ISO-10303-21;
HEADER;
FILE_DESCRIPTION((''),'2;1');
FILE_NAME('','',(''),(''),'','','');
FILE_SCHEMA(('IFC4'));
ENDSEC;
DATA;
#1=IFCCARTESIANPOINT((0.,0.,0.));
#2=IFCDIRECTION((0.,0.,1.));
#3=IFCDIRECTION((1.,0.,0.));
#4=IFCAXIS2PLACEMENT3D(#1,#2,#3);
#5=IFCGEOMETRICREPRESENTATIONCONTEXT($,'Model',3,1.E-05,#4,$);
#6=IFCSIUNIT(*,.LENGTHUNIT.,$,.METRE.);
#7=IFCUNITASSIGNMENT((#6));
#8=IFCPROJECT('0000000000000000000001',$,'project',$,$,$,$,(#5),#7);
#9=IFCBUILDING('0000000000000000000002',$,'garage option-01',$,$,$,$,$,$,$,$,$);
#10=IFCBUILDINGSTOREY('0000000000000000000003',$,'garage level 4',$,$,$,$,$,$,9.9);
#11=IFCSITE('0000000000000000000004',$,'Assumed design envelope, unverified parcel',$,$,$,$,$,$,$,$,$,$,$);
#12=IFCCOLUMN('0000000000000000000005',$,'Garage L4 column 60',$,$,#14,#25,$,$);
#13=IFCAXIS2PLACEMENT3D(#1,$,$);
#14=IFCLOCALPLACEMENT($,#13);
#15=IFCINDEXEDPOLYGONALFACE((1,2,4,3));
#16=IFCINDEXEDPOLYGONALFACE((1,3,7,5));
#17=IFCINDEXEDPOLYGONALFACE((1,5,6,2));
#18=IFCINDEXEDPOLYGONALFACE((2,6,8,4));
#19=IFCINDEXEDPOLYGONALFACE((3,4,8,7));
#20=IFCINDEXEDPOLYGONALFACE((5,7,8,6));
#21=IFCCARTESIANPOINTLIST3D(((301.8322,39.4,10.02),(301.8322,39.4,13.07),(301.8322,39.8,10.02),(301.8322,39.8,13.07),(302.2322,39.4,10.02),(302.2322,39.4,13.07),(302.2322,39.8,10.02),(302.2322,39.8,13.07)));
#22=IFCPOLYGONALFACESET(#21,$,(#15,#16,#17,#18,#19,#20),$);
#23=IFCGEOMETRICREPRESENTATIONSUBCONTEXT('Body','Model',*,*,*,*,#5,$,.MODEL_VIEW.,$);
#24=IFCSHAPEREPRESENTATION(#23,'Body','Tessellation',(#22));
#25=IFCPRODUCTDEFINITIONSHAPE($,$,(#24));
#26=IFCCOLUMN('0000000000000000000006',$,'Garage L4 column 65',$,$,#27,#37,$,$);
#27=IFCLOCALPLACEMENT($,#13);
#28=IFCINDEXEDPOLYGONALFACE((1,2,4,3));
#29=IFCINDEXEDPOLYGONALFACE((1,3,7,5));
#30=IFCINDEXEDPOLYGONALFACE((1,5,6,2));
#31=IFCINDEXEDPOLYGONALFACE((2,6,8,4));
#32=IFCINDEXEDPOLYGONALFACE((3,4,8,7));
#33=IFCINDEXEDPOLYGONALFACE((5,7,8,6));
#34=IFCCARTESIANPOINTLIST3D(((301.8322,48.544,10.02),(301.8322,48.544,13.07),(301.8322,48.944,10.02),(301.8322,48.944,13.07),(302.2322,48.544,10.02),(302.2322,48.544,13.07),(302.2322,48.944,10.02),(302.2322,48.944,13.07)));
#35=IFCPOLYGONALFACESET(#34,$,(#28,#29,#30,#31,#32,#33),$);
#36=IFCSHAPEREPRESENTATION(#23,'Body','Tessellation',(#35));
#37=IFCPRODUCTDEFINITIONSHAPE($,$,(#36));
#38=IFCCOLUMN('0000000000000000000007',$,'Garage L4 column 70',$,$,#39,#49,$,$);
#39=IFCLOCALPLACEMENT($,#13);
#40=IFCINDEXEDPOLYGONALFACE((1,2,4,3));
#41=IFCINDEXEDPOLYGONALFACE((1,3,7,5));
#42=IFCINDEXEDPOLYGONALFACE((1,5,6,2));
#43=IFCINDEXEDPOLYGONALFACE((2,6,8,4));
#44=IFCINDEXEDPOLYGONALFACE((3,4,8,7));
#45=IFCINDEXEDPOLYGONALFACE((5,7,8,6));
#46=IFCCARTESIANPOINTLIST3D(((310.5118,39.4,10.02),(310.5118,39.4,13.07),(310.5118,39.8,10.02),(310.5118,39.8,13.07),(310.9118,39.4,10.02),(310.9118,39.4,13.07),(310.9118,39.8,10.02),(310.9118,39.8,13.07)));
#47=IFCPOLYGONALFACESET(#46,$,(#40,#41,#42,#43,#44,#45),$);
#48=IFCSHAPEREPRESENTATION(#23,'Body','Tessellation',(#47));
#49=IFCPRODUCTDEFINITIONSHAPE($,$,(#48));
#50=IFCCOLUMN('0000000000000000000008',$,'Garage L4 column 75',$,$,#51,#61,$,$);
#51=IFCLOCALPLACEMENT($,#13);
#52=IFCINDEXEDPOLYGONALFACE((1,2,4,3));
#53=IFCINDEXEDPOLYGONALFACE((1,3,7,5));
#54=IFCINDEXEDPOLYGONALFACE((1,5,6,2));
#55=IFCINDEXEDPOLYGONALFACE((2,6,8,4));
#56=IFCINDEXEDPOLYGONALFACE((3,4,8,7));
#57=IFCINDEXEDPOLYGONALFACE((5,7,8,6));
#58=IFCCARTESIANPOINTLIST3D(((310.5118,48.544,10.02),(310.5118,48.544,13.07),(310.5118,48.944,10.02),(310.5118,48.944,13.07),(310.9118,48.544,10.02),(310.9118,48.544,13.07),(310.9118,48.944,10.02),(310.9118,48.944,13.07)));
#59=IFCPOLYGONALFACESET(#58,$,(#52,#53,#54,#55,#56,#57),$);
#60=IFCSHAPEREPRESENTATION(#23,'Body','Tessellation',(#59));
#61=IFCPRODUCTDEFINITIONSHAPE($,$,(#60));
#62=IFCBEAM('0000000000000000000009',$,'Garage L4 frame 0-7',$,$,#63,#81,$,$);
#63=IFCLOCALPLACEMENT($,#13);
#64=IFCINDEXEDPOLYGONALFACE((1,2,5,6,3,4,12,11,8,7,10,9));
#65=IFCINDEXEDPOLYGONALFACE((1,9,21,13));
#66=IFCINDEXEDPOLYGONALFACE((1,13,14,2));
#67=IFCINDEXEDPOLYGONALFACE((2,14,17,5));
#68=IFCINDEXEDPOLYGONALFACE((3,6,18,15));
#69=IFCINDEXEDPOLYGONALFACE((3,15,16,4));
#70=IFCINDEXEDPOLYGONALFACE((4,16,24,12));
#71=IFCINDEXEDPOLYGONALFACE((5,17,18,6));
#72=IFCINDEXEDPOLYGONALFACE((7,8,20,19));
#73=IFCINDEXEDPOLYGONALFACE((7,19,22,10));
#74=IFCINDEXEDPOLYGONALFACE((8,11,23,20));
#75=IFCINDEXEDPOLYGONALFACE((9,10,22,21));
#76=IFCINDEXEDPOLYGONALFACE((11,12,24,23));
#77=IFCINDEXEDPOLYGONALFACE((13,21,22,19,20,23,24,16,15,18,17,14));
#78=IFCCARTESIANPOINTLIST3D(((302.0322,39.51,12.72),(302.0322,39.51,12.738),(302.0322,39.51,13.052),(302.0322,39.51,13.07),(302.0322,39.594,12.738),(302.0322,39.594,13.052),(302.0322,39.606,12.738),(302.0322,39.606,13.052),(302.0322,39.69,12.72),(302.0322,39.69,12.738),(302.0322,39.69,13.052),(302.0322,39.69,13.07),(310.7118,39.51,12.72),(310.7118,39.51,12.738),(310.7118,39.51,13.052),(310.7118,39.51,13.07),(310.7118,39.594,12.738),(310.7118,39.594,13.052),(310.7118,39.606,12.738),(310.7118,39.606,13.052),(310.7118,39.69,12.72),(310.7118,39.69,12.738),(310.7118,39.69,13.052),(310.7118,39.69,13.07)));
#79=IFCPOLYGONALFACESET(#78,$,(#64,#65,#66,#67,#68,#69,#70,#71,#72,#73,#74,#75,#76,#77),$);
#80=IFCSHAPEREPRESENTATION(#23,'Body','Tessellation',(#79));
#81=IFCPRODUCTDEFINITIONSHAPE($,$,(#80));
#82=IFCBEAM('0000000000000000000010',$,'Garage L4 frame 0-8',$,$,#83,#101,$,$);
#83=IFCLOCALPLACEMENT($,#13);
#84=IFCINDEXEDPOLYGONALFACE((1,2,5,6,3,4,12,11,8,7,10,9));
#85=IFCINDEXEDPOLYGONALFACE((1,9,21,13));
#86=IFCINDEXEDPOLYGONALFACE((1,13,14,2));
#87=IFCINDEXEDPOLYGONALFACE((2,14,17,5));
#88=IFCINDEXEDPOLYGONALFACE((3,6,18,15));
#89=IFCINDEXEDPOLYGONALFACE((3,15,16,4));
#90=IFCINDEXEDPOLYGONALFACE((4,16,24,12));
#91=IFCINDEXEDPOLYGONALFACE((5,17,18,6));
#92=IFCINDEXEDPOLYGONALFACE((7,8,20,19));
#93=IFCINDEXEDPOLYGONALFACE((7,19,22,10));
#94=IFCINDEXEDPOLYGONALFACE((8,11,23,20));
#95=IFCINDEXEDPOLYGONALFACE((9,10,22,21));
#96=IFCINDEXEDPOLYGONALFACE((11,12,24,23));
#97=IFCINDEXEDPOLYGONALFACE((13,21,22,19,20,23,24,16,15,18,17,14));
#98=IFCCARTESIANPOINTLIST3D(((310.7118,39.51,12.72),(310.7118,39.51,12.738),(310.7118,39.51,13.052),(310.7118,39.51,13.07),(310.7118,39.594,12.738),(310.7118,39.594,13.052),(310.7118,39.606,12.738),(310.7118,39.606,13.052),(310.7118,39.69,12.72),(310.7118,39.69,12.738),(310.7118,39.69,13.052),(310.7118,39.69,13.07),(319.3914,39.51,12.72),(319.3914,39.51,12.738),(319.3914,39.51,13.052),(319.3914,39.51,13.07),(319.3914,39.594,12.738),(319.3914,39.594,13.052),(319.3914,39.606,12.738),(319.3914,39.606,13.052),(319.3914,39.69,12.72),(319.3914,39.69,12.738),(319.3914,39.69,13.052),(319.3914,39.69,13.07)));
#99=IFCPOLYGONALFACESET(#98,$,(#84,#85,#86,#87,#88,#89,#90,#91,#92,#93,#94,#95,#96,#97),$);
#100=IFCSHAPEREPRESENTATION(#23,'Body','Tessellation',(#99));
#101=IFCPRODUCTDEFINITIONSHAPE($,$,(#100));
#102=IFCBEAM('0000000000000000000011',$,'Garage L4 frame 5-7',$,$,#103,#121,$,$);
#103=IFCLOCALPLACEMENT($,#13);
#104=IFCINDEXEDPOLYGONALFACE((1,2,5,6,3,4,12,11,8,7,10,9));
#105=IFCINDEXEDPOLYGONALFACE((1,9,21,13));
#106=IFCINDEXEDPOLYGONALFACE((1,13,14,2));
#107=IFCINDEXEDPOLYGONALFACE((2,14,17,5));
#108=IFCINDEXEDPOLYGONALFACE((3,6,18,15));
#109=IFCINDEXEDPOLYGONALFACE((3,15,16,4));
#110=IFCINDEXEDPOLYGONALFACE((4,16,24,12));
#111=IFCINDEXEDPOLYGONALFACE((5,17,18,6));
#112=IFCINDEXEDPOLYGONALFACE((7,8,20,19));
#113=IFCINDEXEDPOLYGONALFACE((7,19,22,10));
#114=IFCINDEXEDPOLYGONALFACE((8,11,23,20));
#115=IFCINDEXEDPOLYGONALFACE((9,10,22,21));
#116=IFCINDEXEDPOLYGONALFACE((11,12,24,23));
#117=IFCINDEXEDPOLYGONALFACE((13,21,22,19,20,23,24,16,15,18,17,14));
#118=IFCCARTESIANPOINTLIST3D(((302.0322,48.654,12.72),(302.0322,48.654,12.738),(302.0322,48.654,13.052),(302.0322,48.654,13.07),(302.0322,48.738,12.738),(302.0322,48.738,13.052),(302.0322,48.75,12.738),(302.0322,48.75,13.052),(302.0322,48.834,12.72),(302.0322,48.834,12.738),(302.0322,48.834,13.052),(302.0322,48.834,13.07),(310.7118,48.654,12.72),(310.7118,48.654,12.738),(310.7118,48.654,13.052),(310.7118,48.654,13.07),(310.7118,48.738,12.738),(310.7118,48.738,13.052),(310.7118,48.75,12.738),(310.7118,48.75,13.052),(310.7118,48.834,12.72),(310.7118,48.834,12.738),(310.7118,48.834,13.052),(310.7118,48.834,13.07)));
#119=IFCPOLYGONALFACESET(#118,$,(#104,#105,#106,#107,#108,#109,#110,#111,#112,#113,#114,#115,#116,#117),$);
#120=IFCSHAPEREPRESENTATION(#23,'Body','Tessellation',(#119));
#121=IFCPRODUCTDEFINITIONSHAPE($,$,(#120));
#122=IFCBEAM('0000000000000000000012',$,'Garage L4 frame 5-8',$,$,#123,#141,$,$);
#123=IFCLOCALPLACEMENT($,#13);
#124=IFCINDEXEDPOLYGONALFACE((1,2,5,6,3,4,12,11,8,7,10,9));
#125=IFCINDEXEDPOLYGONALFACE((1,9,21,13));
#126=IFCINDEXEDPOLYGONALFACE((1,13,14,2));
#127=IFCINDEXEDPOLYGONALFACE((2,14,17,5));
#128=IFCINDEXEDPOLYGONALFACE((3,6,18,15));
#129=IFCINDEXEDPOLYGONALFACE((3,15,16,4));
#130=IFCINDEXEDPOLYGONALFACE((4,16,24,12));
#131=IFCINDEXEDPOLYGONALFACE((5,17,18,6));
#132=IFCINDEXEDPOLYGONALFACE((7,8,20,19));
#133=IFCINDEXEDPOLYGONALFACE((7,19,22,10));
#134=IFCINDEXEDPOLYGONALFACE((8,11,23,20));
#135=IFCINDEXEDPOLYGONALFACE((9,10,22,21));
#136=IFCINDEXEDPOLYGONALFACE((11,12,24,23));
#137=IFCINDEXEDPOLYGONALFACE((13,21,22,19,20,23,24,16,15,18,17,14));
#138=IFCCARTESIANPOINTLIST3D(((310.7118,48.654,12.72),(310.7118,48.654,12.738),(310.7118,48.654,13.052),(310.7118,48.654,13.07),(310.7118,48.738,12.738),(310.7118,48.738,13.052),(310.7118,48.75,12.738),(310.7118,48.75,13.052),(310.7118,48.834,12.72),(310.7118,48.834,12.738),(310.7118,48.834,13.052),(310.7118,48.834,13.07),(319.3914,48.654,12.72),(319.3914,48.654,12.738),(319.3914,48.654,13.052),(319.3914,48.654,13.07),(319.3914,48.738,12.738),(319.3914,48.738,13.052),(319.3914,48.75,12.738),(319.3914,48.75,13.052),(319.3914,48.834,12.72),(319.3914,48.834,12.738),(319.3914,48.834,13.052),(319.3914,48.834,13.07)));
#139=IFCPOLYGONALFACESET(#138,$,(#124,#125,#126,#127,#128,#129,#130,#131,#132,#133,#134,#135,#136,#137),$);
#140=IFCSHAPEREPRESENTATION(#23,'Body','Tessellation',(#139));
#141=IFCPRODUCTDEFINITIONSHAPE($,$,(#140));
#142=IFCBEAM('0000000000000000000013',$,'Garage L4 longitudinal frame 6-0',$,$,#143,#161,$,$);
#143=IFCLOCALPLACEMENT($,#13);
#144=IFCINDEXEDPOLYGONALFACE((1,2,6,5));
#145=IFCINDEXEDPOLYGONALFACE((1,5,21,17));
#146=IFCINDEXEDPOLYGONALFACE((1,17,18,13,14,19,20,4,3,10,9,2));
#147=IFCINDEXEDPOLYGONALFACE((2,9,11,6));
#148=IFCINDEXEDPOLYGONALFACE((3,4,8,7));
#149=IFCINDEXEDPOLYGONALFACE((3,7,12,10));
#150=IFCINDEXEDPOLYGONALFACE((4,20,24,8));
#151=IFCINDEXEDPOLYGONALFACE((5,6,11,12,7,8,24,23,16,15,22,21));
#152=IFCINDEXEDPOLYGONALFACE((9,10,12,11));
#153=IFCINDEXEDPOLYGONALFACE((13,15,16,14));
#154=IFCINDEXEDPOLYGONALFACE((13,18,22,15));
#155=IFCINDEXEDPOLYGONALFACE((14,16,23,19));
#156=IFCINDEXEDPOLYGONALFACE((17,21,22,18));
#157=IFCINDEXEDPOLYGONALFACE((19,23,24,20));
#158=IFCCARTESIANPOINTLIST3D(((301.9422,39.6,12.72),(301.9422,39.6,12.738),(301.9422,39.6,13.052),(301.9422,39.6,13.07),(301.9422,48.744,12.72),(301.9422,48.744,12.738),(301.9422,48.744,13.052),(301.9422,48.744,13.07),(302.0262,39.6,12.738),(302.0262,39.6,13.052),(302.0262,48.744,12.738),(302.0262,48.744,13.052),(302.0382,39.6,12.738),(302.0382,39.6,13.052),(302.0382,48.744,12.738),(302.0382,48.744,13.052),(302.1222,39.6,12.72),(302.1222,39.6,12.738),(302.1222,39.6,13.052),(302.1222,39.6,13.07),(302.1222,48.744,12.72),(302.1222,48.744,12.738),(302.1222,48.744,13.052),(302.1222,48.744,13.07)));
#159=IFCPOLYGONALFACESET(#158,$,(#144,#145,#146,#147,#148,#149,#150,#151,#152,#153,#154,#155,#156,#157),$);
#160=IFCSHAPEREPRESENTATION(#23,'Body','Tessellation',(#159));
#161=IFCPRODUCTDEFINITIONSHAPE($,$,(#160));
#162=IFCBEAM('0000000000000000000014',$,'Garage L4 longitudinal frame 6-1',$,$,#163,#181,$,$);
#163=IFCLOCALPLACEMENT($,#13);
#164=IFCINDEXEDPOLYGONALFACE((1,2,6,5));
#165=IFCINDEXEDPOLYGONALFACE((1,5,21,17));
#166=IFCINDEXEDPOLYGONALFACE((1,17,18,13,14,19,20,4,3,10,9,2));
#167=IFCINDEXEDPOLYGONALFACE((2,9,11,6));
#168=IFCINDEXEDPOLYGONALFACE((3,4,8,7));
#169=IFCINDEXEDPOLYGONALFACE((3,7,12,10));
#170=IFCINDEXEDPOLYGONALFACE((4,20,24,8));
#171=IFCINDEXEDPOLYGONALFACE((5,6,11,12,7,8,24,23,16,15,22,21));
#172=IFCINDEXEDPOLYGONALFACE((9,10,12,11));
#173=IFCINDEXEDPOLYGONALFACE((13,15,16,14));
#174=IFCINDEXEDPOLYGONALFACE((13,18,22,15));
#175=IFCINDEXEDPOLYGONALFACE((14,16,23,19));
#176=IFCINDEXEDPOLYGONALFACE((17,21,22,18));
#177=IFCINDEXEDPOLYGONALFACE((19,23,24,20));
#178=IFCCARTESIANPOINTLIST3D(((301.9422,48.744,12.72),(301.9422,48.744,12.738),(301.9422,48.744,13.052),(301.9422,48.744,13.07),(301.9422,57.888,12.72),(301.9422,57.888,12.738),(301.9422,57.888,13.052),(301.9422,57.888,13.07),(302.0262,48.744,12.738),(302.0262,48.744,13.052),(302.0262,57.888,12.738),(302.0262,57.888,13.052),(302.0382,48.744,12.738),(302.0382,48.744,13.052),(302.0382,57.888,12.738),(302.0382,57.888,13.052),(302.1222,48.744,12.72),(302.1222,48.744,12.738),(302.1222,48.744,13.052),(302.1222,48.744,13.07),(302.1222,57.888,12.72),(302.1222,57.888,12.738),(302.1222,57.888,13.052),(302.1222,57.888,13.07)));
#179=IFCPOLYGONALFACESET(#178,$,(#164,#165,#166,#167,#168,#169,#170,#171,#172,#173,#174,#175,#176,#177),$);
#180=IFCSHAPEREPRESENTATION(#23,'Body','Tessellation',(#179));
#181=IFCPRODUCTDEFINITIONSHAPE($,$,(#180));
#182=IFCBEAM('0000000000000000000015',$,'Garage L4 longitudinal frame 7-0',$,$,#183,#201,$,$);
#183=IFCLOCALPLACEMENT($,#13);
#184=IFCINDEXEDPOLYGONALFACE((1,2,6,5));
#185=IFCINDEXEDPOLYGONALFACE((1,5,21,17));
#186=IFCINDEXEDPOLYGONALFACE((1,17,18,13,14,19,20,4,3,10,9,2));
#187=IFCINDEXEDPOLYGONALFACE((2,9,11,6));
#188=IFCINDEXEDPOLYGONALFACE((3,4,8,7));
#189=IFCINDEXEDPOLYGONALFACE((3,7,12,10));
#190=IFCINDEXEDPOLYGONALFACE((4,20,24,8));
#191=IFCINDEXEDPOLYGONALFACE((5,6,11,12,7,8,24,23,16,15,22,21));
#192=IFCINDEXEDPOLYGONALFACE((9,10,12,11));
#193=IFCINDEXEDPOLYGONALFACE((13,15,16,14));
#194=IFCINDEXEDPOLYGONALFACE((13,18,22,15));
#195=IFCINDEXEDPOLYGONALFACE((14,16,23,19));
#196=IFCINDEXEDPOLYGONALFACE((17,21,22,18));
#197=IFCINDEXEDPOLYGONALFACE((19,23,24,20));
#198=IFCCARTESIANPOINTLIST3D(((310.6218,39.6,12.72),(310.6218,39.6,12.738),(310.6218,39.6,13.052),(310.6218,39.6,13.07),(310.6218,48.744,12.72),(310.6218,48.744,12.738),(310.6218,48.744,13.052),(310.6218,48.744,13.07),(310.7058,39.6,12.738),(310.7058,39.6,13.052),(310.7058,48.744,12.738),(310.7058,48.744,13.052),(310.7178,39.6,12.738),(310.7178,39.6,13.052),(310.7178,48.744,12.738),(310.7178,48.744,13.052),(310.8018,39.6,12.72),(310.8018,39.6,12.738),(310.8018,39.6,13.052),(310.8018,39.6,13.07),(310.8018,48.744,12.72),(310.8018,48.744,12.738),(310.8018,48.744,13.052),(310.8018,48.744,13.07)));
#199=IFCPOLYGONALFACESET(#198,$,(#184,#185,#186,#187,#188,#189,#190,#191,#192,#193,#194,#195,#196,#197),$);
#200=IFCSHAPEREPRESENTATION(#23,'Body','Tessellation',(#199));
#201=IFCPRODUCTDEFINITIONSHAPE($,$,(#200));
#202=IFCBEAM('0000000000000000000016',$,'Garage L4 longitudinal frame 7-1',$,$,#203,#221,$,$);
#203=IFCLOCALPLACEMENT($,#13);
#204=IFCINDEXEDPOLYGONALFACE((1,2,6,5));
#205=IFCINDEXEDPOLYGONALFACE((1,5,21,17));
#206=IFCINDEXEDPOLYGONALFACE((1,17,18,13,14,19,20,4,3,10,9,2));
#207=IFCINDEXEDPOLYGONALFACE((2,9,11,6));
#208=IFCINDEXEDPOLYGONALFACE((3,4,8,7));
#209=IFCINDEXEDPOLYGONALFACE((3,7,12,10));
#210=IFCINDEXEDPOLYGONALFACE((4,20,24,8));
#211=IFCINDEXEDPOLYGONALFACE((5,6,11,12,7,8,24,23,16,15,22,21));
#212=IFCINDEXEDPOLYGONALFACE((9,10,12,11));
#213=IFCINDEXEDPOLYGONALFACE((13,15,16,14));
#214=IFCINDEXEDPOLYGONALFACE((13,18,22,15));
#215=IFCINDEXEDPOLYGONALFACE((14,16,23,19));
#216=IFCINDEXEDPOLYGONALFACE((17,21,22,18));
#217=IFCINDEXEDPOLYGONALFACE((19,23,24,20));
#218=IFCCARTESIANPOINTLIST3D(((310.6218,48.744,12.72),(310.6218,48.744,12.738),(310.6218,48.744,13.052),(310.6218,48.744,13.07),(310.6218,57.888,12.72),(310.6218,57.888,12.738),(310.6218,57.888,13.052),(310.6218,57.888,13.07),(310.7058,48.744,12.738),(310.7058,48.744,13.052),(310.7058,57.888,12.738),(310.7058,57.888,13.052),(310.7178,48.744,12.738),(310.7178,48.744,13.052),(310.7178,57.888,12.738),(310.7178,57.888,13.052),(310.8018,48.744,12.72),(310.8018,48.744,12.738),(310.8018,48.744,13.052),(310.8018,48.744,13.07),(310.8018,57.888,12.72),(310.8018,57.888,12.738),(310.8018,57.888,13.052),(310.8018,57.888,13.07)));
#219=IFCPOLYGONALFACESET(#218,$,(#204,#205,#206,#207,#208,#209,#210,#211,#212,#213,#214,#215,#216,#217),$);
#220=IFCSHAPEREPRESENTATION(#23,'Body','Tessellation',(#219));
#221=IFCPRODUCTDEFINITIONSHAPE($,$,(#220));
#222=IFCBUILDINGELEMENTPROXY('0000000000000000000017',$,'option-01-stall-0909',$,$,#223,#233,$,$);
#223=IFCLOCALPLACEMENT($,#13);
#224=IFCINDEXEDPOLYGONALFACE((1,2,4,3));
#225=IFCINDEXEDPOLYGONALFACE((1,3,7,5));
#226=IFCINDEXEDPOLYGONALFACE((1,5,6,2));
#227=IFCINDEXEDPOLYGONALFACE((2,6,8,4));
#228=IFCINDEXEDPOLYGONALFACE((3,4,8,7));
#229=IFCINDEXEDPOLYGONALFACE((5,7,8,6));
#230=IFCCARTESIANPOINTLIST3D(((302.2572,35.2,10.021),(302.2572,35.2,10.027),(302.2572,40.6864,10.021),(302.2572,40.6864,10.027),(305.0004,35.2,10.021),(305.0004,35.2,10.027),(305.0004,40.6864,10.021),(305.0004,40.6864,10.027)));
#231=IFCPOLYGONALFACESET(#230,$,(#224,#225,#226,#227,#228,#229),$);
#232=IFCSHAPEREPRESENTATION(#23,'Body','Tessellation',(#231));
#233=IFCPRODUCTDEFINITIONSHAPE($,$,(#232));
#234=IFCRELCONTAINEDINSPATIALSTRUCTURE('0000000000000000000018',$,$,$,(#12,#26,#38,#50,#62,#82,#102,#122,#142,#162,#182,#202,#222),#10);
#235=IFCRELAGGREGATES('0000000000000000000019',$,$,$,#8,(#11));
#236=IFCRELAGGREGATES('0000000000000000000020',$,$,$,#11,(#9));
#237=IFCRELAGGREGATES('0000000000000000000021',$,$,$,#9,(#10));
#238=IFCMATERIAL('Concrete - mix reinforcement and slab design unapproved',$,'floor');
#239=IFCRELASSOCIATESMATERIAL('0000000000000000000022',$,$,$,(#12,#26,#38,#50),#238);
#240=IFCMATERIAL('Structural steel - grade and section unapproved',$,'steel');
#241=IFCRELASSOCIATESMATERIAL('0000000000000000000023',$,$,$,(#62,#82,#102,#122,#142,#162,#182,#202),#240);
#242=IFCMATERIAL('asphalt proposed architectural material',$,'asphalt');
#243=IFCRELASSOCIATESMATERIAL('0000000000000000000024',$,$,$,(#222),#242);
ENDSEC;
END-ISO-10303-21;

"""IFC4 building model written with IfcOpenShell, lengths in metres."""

from ifc_helpers import new_model, si_unit, frame, origin_with_axes, place, context, subcontext, project, spatial, rectangle, i_section, extrude, material, element, save


model = new_model("IFC4")

# Units and contexts
model_context = context("Model", 3, precision=1e-05, world=origin_with_axes())
body_context = subcontext(model_context, "Body", "Model", "MODEL_VIEW")
ifc_project = project(units=[si_unit("LENGTHUNIT", "METRE")], contexts=[model_context])

# Site, building, storey
site = spatial("IfcSite", under=ifc_project, Name="Assumed design envelope, unverified parcel")
building = spatial("IfcBuilding", under=site, Name="garage option-01")
storey = spatial("IfcBuildingStorey", under=building, Name="garage level 4", Elevation=9.9)

# Columns
ifc_material_1 = material(Name="Concrete - mix reinforcement and slab design unapproved", Category="floor")
for number, where, z_axis, x_axis, name in (
    (1, (302.0322, 39.6, 10.02), (0.0, 0.0, 1.0), (1.0, 0.0, 0.0), "Garage L4 column 60"),
    (2, (302.0322, 48.744, 10.02), (0.0, 0.0, 1.0), (1.0, 0.0, 0.0), "Garage L4 column 65"),
    (3, (310.7118, 39.6, 10.02), (0.0, 0.0, 1.0), (1.0, 0.0, 0.0), "Garage L4 column 70"),
    (4, (310.7118, 48.744, 10.02), (0.0, 0.0, 1.0), (1.0, 0.0, 0.0), "Garage L4 column 75"),
):
    element("IfcColumn", number, at=place(None, frame(where, z_axis=z_axis, x_axis=x_axis)), inside=storey, material=ifc_material_1, Name=name, context=body_context, shape_type="SweptSolid", body=[
        extrude(rectangle(XDim=0.4, YDim=0.4), origin_with_axes(), (0.0, 0.0, 1.0), 3.05),
    ])

# Beams
ifc_material_2 = material(Name="Structural steel - grade and section unapproved", Category="steel")
for number, where, z_axis, x_axis, name in (
    (5, (302.0322, 39.6, 12.895), (1.0, 0.0, 0.0), (0.0, 1.0, 0.0), "Garage L4 frame 0-7"),
    (6, (310.7118, 39.6, 12.895), (1.0, 0.0, 0.0), (0.0, 1.0, 0.0), "Garage L4 frame 0-8"),
    (7, (302.0322, 48.744, 12.895), (1.0, 0.0, 0.0), (0.0, 1.0, 0.0), "Garage L4 frame 5-7"),
    (8, (310.7118, 48.744, 12.895), (1.0, 0.0, 0.0), (0.0, 1.0, 0.0), "Garage L4 frame 5-8"),
):
    element("IfcBeam", number, at=place(None, frame(where, z_axis=z_axis, x_axis=x_axis)), inside=storey, material=ifc_material_2, Name=name, context=body_context, shape_type="SweptSolid", body=[
        extrude(i_section(OverallWidth=0.18, OverallDepth=0.35, WebThickness=0.012, FlangeThickness=0.018, FilletRadius=0.0), origin_with_axes(), (0.0, 0.0, 1.0), 8.6796),
    ])
for number, where, z_axis, x_axis, name in (
    (9, (302.0322, 39.6, 12.895), (0.0, 1.0, 0.0), (-1.0, 0.0, 0.0), "Garage L4 longitudinal frame 6-0"),
    (10, (302.0322, 48.744, 12.895), (0.0, 1.0, 0.0), (-1.0, 0.0, 0.0), "Garage L4 longitudinal frame 6-1"),
    (11, (310.7118, 39.6, 12.895), (0.0, 1.0, 0.0), (-1.0, 0.0, 0.0), "Garage L4 longitudinal frame 7-0"),
    (12, (310.7118, 48.744, 12.895), (0.0, 1.0, 0.0), (-1.0, 0.0, 0.0), "Garage L4 longitudinal frame 7-1"),
):
    element("IfcBeam", number, at=place(None, frame(where, z_axis=z_axis, x_axis=x_axis)), inside=storey, material=ifc_material_2, Name=name, context=body_context, shape_type="SweptSolid", body=[
        extrude(i_section(OverallWidth=0.18, OverallDepth=0.35, WebThickness=0.012, FlangeThickness=0.018, FilletRadius=0.0), origin_with_axes(), (0.0, 0.0, 1.0), 9.144),
    ])

# Building element proxy
ifc_material_3 = material(Name="asphalt proposed architectural material", Category="asphalt")
for number, where, z_axis, x_axis, name in (
    (13, (303.6288, 37.9432, 10.021), (0.0, 0.0, 1.0), (1.0, 0.0, 0.0), "option-01-stall-0909"),
):
    element("IfcBuildingElementProxy", number, at=place(None, frame(where, z_axis=z_axis, x_axis=x_axis)), inside=storey, material=ifc_material_3, Name=name, context=body_context, shape_type="SweptSolid", body=[
        extrude(rectangle(XDim=2.7432, YDim=5.4864), origin_with_axes(), (0.0, 0.0, 1.0), 0.006),
    ])

save(model, "model.ifc")
